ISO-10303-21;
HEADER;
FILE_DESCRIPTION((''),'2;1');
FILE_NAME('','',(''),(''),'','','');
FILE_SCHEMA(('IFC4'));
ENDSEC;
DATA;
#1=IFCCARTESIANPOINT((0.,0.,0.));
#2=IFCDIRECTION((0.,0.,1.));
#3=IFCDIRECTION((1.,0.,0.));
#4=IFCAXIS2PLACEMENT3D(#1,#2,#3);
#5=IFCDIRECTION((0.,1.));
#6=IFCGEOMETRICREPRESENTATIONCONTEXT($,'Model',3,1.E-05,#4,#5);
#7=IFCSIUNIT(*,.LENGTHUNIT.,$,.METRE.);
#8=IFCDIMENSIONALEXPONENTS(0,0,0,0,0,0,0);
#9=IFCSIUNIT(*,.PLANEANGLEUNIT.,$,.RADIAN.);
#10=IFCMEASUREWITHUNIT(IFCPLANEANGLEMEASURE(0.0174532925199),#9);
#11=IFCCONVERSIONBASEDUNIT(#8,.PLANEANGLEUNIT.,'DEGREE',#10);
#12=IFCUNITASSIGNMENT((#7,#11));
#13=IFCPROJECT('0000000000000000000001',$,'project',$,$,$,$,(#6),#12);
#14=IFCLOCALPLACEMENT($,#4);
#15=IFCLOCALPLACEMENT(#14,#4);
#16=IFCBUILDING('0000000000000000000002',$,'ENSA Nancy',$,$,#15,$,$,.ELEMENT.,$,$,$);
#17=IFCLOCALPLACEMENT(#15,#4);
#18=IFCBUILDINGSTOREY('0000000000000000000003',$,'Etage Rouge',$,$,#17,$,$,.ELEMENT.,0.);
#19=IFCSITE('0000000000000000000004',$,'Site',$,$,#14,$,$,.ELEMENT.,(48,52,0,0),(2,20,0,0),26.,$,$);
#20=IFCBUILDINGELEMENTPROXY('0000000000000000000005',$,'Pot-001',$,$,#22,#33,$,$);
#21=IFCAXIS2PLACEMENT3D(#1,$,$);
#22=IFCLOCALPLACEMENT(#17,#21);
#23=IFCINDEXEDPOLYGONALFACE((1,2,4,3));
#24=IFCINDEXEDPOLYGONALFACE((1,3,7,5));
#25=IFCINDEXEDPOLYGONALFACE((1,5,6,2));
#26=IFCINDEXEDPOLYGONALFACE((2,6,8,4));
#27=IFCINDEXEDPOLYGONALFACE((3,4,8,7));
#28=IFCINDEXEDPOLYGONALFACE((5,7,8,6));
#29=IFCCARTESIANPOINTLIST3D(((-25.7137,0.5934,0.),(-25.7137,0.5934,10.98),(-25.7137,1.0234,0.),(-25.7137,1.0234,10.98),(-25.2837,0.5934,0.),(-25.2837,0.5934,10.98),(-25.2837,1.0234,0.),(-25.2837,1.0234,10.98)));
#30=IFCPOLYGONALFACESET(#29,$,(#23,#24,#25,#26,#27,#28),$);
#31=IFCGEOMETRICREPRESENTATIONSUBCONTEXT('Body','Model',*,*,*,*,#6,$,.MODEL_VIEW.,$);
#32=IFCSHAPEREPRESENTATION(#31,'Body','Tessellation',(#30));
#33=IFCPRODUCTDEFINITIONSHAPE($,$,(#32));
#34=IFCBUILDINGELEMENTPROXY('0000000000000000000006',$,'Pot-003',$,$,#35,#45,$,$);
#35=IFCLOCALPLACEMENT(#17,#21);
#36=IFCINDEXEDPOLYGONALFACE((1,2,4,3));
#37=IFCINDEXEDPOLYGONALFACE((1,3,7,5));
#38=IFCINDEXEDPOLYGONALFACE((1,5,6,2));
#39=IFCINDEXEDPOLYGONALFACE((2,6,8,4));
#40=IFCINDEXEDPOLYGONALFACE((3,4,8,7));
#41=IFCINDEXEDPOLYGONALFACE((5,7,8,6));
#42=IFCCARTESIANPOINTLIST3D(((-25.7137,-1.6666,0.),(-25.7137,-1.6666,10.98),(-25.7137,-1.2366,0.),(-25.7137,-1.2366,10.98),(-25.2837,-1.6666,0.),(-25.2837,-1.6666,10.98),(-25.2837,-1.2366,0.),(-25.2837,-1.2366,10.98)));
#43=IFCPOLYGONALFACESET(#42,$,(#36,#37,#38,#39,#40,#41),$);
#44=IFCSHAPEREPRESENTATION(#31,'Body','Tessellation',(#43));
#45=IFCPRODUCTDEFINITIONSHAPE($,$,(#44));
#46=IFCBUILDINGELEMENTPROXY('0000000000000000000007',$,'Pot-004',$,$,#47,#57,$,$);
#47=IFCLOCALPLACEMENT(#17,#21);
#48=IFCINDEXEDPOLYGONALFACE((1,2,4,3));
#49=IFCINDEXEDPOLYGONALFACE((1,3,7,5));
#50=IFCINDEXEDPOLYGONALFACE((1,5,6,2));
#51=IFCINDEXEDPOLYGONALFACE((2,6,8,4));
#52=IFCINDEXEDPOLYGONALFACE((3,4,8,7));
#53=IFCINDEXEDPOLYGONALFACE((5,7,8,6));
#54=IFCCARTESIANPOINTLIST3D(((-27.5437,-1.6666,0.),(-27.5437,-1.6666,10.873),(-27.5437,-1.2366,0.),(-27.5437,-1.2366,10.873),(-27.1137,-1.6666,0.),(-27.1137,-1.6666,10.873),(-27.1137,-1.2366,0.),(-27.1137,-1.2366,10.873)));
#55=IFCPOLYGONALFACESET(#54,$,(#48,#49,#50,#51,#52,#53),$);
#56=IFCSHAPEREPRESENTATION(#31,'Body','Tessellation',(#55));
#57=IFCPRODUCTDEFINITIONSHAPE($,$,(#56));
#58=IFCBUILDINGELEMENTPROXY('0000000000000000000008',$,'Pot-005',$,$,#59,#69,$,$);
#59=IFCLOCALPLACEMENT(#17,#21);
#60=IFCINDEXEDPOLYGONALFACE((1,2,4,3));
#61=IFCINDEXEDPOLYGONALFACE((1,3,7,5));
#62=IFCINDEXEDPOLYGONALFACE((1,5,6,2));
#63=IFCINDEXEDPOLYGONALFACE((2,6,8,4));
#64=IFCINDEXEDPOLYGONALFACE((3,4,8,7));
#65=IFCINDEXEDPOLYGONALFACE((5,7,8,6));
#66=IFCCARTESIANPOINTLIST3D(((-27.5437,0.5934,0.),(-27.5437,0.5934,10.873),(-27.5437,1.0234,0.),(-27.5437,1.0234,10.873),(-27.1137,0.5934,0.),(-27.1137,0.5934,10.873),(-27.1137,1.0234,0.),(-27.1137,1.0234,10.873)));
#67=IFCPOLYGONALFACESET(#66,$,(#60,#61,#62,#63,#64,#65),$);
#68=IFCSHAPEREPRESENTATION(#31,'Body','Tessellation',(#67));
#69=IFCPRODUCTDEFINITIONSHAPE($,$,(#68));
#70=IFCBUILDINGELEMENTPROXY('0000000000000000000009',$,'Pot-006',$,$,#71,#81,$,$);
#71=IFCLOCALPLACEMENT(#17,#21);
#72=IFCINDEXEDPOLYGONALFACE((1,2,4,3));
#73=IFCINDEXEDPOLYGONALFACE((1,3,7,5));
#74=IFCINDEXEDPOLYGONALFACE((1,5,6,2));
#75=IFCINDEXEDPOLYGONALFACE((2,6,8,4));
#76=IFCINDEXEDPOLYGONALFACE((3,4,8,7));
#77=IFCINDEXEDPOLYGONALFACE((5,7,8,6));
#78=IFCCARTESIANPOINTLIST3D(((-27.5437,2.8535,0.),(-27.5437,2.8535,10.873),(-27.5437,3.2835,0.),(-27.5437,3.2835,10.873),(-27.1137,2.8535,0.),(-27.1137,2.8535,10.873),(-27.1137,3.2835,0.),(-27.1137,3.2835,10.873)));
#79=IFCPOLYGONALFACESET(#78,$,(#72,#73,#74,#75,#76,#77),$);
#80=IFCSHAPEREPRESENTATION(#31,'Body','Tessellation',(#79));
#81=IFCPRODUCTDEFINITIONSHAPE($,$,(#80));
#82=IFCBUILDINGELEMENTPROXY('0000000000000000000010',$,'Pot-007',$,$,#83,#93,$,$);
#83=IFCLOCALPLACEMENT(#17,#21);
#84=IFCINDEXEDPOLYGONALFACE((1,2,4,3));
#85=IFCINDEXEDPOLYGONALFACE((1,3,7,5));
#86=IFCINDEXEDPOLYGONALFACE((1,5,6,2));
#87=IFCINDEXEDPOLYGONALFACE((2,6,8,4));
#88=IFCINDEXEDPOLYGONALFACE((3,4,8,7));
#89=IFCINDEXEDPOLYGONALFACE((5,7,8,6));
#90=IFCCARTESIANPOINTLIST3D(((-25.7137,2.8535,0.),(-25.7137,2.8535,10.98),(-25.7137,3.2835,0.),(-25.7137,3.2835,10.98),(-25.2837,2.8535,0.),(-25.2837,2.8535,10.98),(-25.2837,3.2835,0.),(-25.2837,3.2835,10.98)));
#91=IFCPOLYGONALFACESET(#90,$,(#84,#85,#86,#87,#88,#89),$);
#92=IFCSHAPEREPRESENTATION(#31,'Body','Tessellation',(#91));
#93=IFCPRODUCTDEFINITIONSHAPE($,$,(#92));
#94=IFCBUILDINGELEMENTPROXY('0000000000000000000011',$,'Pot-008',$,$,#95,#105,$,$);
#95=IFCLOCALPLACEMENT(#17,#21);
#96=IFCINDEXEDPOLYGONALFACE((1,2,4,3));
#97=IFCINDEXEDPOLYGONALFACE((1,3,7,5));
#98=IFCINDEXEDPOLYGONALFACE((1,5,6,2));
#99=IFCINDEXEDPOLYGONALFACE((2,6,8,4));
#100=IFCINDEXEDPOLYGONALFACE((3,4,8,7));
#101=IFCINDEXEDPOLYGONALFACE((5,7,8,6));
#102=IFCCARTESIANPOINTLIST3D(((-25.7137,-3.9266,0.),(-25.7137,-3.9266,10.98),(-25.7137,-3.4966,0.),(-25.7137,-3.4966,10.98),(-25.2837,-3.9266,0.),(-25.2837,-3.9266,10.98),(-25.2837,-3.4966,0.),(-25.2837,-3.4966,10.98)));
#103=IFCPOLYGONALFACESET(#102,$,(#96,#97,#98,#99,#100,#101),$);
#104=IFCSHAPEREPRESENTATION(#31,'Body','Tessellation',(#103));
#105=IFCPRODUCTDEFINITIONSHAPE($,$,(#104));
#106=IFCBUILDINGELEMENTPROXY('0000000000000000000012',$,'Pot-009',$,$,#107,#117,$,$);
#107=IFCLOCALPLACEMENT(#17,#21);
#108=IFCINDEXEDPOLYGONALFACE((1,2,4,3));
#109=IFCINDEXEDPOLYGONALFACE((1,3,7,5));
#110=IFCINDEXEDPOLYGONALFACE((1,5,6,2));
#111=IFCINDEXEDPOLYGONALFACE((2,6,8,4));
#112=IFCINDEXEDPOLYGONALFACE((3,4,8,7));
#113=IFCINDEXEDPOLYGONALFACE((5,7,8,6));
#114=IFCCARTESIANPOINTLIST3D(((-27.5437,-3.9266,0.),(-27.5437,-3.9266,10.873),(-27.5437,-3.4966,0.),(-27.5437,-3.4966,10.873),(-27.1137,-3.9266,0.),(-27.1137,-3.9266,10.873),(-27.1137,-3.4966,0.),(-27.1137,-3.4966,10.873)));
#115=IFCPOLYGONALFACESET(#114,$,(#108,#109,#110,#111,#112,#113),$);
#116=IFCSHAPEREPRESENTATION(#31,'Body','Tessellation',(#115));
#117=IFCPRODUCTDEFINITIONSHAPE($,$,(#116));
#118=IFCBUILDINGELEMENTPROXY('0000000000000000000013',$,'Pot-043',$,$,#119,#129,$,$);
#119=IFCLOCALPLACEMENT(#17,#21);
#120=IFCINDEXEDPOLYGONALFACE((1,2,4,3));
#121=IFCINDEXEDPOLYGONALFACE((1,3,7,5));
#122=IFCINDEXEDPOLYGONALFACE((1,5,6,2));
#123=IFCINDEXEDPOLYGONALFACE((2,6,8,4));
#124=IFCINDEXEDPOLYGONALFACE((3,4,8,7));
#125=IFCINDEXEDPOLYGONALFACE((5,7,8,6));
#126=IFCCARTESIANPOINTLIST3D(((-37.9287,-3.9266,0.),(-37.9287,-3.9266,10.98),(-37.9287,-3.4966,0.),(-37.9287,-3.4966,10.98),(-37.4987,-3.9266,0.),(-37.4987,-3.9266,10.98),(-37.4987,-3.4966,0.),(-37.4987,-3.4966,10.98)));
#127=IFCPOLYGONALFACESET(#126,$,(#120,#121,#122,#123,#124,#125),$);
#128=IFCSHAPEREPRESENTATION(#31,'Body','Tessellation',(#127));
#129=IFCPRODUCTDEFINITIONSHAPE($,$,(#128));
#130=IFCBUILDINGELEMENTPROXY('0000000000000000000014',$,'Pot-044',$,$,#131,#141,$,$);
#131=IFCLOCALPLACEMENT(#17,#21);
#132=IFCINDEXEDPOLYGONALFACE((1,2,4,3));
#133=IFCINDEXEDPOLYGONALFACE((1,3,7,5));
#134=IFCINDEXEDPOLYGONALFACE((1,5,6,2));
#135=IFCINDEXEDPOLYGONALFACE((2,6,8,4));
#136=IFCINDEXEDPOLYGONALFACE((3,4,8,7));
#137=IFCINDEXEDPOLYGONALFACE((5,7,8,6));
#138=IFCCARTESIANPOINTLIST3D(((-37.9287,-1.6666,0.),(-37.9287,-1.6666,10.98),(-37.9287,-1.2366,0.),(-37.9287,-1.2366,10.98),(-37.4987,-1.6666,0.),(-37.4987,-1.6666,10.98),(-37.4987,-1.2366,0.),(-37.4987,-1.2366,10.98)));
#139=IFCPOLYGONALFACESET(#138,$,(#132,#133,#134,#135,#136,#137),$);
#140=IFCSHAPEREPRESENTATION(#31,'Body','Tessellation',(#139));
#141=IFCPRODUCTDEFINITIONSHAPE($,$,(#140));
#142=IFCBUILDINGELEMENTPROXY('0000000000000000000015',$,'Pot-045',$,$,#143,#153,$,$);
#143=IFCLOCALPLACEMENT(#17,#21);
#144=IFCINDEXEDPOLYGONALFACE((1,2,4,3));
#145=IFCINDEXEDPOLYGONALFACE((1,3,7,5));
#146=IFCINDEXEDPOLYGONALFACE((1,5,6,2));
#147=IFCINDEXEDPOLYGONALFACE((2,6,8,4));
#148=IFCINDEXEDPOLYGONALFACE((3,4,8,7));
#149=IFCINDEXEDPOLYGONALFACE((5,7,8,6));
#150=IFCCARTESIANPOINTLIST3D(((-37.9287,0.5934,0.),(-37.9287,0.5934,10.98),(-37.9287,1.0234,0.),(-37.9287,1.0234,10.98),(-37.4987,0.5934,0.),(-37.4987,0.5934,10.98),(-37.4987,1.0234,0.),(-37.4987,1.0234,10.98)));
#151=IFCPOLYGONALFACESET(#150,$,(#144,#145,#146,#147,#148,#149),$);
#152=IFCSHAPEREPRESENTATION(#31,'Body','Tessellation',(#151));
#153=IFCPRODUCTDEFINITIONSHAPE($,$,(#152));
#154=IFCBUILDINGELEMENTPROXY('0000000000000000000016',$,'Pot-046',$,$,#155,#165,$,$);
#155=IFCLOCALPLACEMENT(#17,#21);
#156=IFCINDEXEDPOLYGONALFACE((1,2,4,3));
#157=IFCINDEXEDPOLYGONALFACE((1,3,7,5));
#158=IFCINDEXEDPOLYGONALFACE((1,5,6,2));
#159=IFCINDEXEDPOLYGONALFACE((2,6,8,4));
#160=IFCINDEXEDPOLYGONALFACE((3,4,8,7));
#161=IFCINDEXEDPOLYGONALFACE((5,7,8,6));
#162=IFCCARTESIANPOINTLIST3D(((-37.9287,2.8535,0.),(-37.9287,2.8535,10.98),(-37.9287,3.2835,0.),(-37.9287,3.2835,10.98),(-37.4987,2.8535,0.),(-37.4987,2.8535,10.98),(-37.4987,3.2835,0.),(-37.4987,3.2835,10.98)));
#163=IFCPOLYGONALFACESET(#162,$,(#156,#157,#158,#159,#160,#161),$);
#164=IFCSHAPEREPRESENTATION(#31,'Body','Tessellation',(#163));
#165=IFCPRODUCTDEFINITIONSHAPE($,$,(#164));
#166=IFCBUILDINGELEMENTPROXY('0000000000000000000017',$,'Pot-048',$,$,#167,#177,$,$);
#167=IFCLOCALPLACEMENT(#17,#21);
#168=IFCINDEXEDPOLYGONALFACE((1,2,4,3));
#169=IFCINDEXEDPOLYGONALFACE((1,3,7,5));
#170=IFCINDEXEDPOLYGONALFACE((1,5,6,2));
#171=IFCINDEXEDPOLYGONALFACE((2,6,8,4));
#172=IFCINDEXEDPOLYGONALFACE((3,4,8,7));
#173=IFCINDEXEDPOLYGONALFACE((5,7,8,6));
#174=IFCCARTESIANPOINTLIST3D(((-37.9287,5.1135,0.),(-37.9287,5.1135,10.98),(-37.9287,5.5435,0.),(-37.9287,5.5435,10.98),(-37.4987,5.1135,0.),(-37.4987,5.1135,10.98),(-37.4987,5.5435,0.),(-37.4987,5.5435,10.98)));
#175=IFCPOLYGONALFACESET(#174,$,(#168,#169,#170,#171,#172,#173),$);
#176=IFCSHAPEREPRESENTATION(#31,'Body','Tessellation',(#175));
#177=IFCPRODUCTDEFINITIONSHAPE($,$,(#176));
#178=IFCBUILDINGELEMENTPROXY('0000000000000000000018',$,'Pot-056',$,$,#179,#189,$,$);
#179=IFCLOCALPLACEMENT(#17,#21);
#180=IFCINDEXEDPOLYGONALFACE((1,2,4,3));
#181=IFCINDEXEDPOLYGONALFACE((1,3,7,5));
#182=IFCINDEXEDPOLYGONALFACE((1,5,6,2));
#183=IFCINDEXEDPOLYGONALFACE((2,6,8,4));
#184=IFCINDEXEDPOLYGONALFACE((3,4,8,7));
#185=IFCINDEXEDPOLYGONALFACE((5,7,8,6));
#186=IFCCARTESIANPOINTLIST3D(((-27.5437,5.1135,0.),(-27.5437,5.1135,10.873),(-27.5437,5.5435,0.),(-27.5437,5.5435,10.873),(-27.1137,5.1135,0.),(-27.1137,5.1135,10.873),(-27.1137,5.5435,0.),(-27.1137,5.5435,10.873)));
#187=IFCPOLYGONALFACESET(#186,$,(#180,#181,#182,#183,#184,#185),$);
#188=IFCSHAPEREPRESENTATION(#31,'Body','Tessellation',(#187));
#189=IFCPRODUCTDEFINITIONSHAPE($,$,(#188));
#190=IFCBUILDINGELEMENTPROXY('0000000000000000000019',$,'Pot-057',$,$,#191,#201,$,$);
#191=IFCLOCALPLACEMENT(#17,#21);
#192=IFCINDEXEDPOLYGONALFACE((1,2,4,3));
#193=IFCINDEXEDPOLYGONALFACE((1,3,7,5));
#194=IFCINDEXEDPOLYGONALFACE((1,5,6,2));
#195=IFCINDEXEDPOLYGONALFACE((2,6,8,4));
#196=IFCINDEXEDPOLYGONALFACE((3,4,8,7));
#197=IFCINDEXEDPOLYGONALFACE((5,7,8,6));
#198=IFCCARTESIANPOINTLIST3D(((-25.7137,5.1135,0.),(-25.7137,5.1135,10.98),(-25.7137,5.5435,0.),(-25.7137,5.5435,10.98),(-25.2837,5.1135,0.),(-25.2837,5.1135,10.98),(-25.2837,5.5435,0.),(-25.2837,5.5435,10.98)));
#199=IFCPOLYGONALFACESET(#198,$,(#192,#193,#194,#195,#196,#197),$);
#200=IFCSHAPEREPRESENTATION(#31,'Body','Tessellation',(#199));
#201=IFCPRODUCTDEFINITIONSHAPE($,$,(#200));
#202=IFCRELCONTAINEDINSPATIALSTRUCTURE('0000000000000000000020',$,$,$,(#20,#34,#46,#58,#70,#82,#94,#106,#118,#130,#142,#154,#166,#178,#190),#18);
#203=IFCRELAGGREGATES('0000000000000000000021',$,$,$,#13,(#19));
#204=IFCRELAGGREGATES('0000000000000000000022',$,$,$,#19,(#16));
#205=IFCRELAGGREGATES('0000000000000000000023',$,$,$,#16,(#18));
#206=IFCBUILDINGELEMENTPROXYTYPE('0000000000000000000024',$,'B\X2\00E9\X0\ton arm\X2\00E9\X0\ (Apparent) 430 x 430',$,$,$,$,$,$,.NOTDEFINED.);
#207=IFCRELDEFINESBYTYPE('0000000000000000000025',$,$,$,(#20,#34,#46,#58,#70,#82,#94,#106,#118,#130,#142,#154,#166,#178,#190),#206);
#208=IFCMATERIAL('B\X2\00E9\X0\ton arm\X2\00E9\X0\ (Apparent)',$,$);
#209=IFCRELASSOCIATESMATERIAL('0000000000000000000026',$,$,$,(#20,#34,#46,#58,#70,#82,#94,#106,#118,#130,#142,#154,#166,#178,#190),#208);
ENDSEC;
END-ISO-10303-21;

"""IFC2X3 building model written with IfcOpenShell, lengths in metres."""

from ifc_helpers import new_model, entity, si_unit, converted_unit, direction, frame, origin_with_axes, origin_2d_with_axis, place, context, subcontext, project, spatial, rectangle, extrude, material, type_object, element, save


model = new_model("IFC2X3")

# Units and contexts
model_context = context("Model", 3, precision=1e-05, world=origin_with_axes(), true_north=direction((0.0, 1.0)))
body_context = subcontext(model_context, "Body", "Model", "MODEL_VIEW")
ifc_project = project(units=[si_unit("LENGTHUNIT", "METRE"), converted_unit("PLANEANGLEUNIT", "DEGREE", entity("IfcPlaneAngleMeasure", 0.0174532925199), si_unit("PLANEANGLEUNIT", "RADIAN"), dimensions=[0, 0, 0, 0, 0, 0, 0])], contexts=[model_context])

# Site, building, storey
site_placement = place(None, origin_with_axes())
site = spatial("IfcSite", under=ifc_project, at=site_placement, Name="Site", CompositionType="ELEMENT", RefLatitude=(48, 52, 0, 0), RefLongitude=(2, 20, 0, 0), RefElevation=26.0)
building_placement = place(site_placement, origin_with_axes())
building = spatial("IfcBuilding", under=site, at=building_placement, Name="ENSA Nancy", CompositionType="ELEMENT")
storey_placement = place(building_placement, origin_with_axes())
storey = spatial("IfcBuildingStorey", under=building, at=storey_placement, Name="Etage Rouge", CompositionType="ELEMENT", Elevation=0.0)

# Building element proxies
ifc_material_1 = material(Name="Béton armé (Apparent)")
building_element_proxy_type_1 = type_object("IfcBuildingElementProxyType", Name="Béton armé (Apparent) 430 x 430", PredefinedType="NOTDEFINED")
for number, where, z_axis, x_axis, name in (
    (1, (-25.4987, 0.8084, 0.0), (0.0, 0.0, 1.0), (1.0, 0.0, 0.0), "Pot-001"),
    (2, (-25.4987, -1.4516, 0.0), (0.0, 0.0, 1.0), (1.0, 0.0, 0.0), "Pot-003"),
):
    element("IfcBuildingElementProxy", number, at=place(storey_placement, frame(where, z_axis=z_axis, x_axis=x_axis)), inside=storey, type_object=building_element_proxy_type_1, material=ifc_material_1, Name=name, context=body_context, shape_type="SweptSolid", body=[
        extrude(rectangle(XDim=0.43, YDim=0.43, at=origin_2d_with_axis()), origin_with_axes(), (0.0, 0.0, 1.0), 10.98),
    ])
for number, where, z_axis, x_axis, name in (
    (3, (-27.3287, -1.4516, 0.0), (0.0, 0.0, 1.0), (1.0, 0.0, 0.0), "Pot-004"),
    (4, (-27.3287, 0.8084, 0.0), (0.0, 0.0, 1.0), (1.0, 0.0, 0.0), "Pot-005"),
    (5, (-27.3287, 3.0685, 0.0), (0.0, 0.0, 1.0), (1.0, 0.0, 0.0), "Pot-006"),
):
    element("IfcBuildingElementProxy", number, at=place(storey_placement, frame(where, z_axis=z_axis, x_axis=x_axis)), inside=storey, type_object=building_element_proxy_type_1, material=ifc_material_1, Name=name, context=body_context, shape_type="SweptSolid", body=[
        extrude(rectangle(XDim=0.43, YDim=0.43, at=origin_2d_with_axis()), origin_with_axes(), (0.0, 0.0, 1.0), 10.873),
    ])
for number, where, z_axis, x_axis, name in (
    (6, (-25.4987, 3.0685, 0.0), (0.0, 0.0, 1.0), (1.0, 0.0, 0.0), "Pot-007"),
    (7, (-25.4987, -3.7116, 0.0), (0.0, 0.0, 1.0), (1.0, 0.0, 0.0), "Pot-008"),
):
    element("IfcBuildingElementProxy", number, at=place(storey_placement, frame(where, z_axis=z_axis, x_axis=x_axis)), inside=storey, type_object=building_element_proxy_type_1, material=ifc_material_1, Name=name, context=body_context, shape_type="SweptSolid", body=[
        extrude(rectangle(XDim=0.43, YDim=0.43, at=origin_2d_with_axis()), origin_with_axes(), (0.0, 0.0, 1.0), 10.98),
    ])
proxy_1_placement = place(storey_placement, frame((-27.3287, -3.7116, 0.0), z_axis=(0.0, 0.0, 1.0), x_axis=(1.0, 0.0, 0.0)))
element("IfcBuildingElementProxy", 8, at=proxy_1_placement, inside=storey, type_object=building_element_proxy_type_1, material=ifc_material_1, Name="Pot-009", context=body_context, shape_type="SweptSolid", body=[
    extrude(rectangle(XDim=0.43, YDim=0.43, at=origin_2d_with_axis()), origin_with_axes(), (0.0, 0.0, 1.0), 10.873),
])
for number, where, z_axis, x_axis, name in (
    (9, (-37.7137, -3.7116, 0.0), (0.0, 0.0, 1.0), (1.0, 0.0, 0.0), "Pot-043"),
    (10, (-37.7137, -1.4516, 0.0), (0.0, 0.0, 1.0), (1.0, 0.0, 0.0), "Pot-044"),
    (11, (-37.7137, 0.8084, 0.0), (0.0, 0.0, 1.0), (1.0, 0.0, 0.0), "Pot-045"),
    (12, (-37.7137, 3.0685, 0.0), (0.0, 0.0, 1.0), (1.0, 0.0, 0.0), "Pot-046"),
    (13, (-37.7137, 5.3285, 0.0), (0.0, 0.0, 1.0), (1.0, 0.0, 0.0), "Pot-048"),
):
    element("IfcBuildingElementProxy", number, at=place(storey_placement, frame(where, z_axis=z_axis, x_axis=x_axis)), inside=storey, type_object=building_element_proxy_type_1, material=ifc_material_1, Name=name, context=body_context, shape_type="SweptSolid", body=[
        extrude(rectangle(XDim=0.43, YDim=0.43, at=origin_2d_with_axis()), origin_with_axes(), (0.0, 0.0, 1.0), 10.98),
    ])
proxy_2_placement = place(storey_placement, frame((-27.3287, 5.3285, 0.0), z_axis=(0.0, 0.0, 1.0), x_axis=(1.0, 0.0, 0.0)))
element("IfcBuildingElementProxy", 14, at=proxy_2_placement, inside=storey, type_object=building_element_proxy_type_1, material=ifc_material_1, Name="Pot-056", context=body_context, shape_type="SweptSolid", body=[
    extrude(rectangle(XDim=0.43, YDim=0.43, at=origin_2d_with_axis()), origin_with_axes(), (0.0, 0.0, 1.0), 10.873),
])
proxy_3_placement = place(storey_placement, frame((-25.4987, 5.3285, 0.0), z_axis=(0.0, 0.0, 1.0), x_axis=(1.0, 0.0, 0.0)))
element("IfcBuildingElementProxy", 15, at=proxy_3_placement, inside=storey, type_object=building_element_proxy_type_1, material=ifc_material_1, Name="Pot-057", context=body_context, shape_type="SweptSolid", body=[
    extrude(rectangle(XDim=0.43, YDim=0.43, at=origin_2d_with_axis()), origin_with_axes(), (0.0, 0.0, 1.0), 10.98),
])

save(model, "model.ifc")
